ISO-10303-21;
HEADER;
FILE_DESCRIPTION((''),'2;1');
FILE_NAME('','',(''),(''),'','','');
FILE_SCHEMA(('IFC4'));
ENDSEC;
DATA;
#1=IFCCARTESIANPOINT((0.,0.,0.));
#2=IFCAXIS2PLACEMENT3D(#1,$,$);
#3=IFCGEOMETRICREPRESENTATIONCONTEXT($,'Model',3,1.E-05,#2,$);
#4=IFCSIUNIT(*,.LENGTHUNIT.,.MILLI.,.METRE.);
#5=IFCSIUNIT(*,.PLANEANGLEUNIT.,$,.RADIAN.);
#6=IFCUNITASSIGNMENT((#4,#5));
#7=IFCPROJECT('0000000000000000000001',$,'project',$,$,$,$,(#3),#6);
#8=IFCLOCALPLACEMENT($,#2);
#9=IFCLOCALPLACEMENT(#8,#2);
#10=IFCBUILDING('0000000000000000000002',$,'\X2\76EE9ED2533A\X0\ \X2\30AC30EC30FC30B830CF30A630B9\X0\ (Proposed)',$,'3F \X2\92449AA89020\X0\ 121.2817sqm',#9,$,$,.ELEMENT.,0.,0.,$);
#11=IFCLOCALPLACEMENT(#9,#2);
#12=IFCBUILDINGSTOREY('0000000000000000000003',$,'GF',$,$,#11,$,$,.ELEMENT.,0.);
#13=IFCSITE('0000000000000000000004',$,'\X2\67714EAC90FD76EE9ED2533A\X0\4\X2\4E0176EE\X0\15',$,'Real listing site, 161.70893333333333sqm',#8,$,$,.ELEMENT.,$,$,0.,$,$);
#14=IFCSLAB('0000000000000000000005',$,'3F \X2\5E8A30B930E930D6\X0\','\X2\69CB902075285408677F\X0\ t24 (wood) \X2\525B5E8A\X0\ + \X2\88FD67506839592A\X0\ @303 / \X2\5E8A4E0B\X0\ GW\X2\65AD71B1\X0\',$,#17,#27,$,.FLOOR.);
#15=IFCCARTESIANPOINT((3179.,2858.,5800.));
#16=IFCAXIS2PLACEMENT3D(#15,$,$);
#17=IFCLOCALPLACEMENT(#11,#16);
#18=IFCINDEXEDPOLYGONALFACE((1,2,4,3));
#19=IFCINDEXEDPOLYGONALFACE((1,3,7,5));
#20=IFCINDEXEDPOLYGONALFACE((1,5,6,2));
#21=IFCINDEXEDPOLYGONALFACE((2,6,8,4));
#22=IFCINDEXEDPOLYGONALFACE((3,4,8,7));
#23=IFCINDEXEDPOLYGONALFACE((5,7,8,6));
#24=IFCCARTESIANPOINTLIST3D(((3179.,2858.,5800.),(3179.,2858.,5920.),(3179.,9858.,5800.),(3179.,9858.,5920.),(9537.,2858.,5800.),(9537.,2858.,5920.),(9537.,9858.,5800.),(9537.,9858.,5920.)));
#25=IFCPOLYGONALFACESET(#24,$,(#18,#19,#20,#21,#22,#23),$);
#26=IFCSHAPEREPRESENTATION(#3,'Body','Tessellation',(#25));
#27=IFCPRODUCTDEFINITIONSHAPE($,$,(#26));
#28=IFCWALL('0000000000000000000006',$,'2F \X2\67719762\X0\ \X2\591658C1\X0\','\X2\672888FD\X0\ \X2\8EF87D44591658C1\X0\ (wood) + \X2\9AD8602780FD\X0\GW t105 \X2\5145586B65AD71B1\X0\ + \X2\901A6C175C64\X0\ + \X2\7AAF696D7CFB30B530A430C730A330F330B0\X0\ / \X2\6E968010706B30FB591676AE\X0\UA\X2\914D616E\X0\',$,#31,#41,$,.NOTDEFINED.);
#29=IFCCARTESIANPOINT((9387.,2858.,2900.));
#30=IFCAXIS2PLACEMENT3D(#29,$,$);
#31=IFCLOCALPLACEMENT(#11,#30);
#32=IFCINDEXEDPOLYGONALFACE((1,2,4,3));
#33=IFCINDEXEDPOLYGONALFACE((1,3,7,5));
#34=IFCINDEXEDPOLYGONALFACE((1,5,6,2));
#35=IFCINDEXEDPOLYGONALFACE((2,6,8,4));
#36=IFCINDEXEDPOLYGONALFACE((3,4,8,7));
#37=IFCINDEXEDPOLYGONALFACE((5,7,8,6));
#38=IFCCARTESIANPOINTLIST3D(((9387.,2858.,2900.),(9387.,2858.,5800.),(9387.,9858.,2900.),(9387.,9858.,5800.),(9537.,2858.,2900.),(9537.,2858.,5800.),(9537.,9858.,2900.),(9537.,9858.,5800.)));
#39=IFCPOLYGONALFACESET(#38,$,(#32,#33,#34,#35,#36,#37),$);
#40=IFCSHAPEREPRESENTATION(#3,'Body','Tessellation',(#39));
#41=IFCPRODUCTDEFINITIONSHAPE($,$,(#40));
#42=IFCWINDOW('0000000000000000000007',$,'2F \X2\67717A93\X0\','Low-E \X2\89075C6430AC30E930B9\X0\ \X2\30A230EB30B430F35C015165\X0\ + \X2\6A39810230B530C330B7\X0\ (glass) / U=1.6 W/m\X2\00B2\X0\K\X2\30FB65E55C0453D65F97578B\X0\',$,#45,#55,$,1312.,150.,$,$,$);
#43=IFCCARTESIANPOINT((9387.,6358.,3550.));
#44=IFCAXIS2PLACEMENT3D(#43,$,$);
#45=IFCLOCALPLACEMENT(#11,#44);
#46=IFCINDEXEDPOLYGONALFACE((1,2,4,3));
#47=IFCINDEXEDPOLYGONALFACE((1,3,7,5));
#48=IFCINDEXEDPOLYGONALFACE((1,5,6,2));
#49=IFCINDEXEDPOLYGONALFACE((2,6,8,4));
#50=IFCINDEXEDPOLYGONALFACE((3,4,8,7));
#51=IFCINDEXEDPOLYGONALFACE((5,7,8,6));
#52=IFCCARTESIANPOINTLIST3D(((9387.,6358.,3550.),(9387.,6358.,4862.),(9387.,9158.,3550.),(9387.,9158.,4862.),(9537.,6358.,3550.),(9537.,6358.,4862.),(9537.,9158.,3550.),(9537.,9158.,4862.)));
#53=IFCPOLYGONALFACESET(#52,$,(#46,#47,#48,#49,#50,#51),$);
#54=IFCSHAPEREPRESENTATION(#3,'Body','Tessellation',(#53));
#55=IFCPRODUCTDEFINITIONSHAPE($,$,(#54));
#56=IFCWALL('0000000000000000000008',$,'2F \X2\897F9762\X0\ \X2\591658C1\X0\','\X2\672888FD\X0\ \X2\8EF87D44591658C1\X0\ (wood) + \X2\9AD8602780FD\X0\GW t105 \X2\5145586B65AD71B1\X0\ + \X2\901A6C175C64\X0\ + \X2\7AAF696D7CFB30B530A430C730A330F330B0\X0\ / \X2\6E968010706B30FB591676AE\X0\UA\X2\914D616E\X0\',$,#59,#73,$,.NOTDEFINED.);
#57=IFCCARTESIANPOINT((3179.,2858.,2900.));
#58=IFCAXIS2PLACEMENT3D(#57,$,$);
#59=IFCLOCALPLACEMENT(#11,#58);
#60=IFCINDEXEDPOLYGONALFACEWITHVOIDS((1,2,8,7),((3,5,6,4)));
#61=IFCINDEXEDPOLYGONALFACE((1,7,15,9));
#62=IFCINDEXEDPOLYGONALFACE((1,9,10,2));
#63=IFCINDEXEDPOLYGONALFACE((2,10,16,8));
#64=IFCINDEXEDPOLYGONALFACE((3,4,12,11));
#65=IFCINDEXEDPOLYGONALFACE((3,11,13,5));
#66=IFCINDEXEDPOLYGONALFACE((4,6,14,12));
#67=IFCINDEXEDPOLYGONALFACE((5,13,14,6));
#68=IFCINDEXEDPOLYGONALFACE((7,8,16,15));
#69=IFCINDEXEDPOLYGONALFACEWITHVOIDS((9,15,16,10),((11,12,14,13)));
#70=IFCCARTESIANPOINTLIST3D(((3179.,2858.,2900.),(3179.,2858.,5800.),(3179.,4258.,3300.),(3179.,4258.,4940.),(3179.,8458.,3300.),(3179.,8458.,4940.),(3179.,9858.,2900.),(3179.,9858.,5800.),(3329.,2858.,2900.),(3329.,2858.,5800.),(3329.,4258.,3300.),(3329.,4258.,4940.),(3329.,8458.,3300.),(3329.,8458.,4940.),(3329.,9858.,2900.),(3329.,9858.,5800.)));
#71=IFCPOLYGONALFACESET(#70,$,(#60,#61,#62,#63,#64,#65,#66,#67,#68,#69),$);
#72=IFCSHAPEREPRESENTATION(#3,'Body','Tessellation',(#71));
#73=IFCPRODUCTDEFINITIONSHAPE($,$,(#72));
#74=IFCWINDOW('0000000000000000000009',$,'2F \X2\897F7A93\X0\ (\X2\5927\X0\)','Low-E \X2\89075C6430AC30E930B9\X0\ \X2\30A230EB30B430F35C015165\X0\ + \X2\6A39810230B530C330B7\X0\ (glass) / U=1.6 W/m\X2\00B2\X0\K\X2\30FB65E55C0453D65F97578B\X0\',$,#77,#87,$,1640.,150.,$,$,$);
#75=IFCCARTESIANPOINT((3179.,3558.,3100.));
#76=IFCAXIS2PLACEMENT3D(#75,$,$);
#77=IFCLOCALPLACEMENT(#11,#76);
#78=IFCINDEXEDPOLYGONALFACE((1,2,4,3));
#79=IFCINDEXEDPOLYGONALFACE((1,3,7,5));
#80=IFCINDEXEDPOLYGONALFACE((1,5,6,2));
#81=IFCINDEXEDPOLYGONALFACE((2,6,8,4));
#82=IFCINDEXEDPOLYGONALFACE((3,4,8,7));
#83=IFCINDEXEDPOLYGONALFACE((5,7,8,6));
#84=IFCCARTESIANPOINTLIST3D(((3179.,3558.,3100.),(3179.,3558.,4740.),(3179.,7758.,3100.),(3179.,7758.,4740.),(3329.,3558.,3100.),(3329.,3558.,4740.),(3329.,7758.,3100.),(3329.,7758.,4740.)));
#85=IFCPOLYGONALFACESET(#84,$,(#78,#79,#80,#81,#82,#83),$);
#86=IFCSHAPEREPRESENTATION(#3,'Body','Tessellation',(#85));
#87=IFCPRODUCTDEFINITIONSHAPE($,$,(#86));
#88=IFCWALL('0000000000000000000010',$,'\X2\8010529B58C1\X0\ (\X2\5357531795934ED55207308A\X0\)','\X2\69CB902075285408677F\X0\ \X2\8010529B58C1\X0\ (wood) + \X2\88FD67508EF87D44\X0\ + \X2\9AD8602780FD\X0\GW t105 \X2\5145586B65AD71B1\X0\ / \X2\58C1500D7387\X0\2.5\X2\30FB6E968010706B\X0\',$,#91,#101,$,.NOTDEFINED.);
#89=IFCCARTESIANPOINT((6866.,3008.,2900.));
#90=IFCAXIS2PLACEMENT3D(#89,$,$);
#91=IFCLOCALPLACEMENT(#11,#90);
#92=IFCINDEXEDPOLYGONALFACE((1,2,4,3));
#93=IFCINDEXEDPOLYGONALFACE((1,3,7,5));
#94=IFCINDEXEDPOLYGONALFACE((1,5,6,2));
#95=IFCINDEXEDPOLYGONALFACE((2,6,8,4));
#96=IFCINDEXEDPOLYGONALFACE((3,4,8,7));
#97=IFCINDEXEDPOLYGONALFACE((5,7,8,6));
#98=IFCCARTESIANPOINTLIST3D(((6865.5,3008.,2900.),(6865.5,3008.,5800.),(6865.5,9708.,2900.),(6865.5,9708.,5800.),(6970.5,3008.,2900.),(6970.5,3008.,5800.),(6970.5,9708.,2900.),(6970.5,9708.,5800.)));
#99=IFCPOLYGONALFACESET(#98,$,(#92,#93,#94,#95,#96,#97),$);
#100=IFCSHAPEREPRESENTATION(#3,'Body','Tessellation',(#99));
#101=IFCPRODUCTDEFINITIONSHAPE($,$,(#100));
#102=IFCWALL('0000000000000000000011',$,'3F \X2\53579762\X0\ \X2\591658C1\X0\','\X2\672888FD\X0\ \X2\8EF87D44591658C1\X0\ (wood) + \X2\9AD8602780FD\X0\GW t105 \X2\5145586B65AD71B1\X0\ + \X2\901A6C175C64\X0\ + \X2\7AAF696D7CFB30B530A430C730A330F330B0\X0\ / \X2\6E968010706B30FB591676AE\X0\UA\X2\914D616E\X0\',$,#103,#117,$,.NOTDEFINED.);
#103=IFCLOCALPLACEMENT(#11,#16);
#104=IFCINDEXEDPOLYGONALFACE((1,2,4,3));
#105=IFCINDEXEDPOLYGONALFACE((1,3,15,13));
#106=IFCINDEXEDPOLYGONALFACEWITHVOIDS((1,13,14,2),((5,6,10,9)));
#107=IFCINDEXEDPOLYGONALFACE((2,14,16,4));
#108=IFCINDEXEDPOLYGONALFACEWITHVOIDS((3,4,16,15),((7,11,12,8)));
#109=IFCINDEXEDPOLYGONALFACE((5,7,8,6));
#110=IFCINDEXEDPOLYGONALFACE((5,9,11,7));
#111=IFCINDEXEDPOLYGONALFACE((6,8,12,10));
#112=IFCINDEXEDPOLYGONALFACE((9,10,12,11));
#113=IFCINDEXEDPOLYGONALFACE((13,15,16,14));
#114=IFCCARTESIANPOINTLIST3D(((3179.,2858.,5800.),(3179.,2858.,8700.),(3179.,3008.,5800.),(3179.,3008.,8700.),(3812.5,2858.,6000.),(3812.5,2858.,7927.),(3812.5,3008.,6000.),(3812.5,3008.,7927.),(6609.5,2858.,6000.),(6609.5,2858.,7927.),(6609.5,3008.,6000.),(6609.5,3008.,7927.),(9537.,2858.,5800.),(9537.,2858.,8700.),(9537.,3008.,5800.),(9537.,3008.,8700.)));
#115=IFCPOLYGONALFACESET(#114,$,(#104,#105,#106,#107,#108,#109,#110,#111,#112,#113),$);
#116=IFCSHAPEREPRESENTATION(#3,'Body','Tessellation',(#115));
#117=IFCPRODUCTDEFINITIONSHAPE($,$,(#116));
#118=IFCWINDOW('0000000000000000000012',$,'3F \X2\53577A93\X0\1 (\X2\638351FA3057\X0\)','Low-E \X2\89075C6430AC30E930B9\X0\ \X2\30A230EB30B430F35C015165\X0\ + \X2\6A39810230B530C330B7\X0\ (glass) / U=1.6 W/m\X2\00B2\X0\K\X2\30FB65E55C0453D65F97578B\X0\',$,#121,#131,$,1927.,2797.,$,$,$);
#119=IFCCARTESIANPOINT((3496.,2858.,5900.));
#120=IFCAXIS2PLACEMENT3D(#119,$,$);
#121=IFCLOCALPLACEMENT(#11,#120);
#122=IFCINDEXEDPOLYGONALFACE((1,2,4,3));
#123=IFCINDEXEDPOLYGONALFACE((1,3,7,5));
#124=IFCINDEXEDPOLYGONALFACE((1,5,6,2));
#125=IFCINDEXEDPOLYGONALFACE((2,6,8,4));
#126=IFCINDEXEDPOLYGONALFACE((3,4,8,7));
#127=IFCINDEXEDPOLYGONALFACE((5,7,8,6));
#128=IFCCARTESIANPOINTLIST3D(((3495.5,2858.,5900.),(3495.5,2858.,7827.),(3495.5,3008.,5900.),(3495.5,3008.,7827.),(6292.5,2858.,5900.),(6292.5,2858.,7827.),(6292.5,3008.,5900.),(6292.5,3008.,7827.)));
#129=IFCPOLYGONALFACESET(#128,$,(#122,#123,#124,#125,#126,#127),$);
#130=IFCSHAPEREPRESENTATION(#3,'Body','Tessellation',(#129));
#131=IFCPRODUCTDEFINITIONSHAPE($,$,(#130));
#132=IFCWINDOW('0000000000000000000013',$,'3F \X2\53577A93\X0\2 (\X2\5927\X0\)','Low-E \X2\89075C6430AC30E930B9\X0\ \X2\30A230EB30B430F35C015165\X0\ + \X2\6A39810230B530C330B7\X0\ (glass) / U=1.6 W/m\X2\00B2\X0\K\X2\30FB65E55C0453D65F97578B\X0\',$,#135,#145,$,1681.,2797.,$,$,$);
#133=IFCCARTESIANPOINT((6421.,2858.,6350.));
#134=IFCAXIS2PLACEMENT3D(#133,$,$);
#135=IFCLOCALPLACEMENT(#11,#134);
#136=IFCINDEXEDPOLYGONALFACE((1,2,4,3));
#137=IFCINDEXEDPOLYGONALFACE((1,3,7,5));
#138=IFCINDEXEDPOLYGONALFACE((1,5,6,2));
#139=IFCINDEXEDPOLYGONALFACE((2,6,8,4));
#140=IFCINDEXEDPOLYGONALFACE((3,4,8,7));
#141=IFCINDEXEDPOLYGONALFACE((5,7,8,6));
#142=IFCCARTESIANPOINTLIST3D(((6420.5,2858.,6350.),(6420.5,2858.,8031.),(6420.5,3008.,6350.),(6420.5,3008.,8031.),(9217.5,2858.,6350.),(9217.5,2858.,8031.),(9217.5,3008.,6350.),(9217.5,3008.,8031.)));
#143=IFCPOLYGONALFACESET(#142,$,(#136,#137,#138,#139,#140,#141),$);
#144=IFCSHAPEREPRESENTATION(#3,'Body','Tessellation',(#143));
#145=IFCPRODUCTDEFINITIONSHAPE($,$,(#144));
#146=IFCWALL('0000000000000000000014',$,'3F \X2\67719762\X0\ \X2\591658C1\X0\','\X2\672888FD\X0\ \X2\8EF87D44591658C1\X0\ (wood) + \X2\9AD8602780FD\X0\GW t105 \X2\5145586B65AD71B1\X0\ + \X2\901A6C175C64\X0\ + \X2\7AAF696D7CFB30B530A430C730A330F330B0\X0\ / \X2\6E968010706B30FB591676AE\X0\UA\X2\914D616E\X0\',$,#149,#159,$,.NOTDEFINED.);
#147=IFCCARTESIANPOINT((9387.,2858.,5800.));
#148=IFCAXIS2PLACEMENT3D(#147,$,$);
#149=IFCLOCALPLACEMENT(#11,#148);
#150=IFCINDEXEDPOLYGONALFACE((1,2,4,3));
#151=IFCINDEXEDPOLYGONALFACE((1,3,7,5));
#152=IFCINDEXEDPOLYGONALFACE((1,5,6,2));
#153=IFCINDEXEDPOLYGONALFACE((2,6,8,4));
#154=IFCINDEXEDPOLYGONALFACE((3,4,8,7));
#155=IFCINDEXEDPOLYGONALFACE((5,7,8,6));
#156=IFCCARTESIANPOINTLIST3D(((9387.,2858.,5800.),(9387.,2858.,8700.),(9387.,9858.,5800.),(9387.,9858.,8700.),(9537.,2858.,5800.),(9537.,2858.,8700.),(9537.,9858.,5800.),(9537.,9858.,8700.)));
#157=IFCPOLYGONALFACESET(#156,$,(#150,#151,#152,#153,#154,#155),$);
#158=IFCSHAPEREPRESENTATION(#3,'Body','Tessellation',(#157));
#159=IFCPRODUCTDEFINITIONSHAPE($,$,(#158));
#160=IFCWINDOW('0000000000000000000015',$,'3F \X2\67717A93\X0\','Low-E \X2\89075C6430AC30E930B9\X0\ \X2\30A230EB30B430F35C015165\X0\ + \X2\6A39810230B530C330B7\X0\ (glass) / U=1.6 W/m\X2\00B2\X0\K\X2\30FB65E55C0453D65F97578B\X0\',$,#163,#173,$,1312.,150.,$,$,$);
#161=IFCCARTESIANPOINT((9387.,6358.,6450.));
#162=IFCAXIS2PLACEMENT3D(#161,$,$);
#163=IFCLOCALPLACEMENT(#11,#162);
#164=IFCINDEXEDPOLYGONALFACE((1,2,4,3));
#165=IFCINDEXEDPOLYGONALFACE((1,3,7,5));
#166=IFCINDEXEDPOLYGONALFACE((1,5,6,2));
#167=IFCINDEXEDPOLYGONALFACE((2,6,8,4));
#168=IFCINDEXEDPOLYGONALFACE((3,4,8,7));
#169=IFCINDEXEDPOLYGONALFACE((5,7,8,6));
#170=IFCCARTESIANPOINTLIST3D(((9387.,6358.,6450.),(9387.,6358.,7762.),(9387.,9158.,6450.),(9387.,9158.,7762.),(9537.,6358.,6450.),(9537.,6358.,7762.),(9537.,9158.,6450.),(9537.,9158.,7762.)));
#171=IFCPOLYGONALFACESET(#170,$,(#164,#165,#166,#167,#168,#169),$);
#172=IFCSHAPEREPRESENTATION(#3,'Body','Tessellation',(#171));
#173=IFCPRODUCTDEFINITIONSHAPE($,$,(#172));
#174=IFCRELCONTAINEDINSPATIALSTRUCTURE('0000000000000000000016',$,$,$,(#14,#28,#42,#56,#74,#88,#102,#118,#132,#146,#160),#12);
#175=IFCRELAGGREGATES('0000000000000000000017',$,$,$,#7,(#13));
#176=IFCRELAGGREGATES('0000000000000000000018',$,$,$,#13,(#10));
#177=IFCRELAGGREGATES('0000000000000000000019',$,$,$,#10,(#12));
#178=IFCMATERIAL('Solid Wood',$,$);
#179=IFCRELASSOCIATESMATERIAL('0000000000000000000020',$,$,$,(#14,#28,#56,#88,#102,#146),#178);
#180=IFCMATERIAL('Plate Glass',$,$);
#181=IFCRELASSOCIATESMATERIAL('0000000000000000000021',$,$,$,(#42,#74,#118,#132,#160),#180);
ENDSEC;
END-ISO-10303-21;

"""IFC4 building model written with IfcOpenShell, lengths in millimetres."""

from ifc_helpers import new_model, si_unit, frame, frame_2d, origin, place, context, project, spatial, rectangle, extrude, material, element, fill, save


model = new_model("IFC4")

# Units and contexts
model_context = context("Model", 3, precision=1e-05, world=origin())
ifc_project = project(units=[si_unit("LENGTHUNIT", "METRE", prefix="MILLI"), si_unit("PLANEANGLEUNIT", "RADIAN")], contexts=[model_context])

# Site, building, storey
site_placement = place(None, origin())
site = spatial("IfcSite", under=ifc_project, at=site_placement, Name="東京都目黒区4丁目15", ObjectType="Real listing site, 161.70893333333333sqm", CompositionType="ELEMENT", RefElevation=0.0)
building_placement = place(site_placement, origin())
building = spatial("IfcBuilding", under=site, at=building_placement, Name="目黒区 ガレージハウス (Proposed)", ObjectType="3F 鉄骨造 121.2817sqm", CompositionType="ELEMENT", ElevationOfRefHeight=0.0, ElevationOfTerrain=0.0)
storey_placement = place(building_placement, origin())
storey = spatial("IfcBuildingStorey", under=building, at=storey_placement, Name="GF", CompositionType="ELEMENT", Elevation=0.0)

# Slab
ifc_material_1 = material(Name="Solid Wood")
slab_placement = place(storey_placement, frame((3179.0, 2858.0, 5800.0)))
element("IfcSlab", 1, at=slab_placement, inside=storey, material=ifc_material_1, Name="3F 床スラブ", Description="構造用合板 t24 (wood) 剛床 + 製材根太 @303 / 床下 GW断熱", PredefinedType="FLOOR", context=model_context, shape_type="SweptSolid", body=[
    extrude(rectangle(XDim=6358.0, YDim=7000.0, at=frame_2d((3179.0, 3500.0))), frame((3179.0, 2858.0, 5800.0)), (0.0, 0.0, 1.0), 120.0),
])

# Walls, openings, windows
wall_1_placement = place(storey_placement, frame((9387.0, 2858.0, 2900.0)))
wall_1 = element("IfcWall", 2, at=wall_1_placement, inside=storey, material=ifc_material_1, Name="2F 東面 外壁", Description="木製 軸組外壁 (wood) + 高性能GW t105 充填断熱 + 通気層 + 窯業系サイディング / 準耐火・外皮UA配慮", PredefinedType="NOTDEFINED", context=model_context, shape_type="SweptSolid", body=[
    extrude(rectangle(XDim=150.0, YDim=7000.0, at=frame_2d((75.0, 3500.0))), frame((9387.0, 2858.0, 2900.0)), (0.0, 0.0, 1.0), 2900.0),
])
opening_1_placement = place(storey_placement, frame((9387.0, 6358.0, 3550.0)))
opening_1 = element("IfcOpeningElement", 3, at=opening_1_placement, cuts=wall_1, PredefinedType="NOTDEFINED", context=model_context, shape_type="SweptSolid", body=[
    extrude(rectangle(XDim=150.0, YDim=2800.0, at=frame_2d((75.0, 1400.0))), frame((9387.0, 6358.0, 3550.0)), (0.0, 0.0, 1.0), 1312.0),
])
ifc_material_2 = material(Name="Plate Glass")
window_1_placement = place(storey_placement, frame((9387.0, 6358.0, 3550.0)))
window_1 = element("IfcWindow", 4, at=window_1_placement, inside=storey, material=ifc_material_2, Name="2F 東窓", Description="Low-E 複層ガラス アルゴン封入 + 樹脂サッシ (glass) / U=1.6 W/m²K・日射取得型", OverallHeight=1312.0, OverallWidth=150.0, context=model_context, shape_type="SweptSolid", body=[
    extrude(rectangle(XDim=150.0, YDim=2800.0, at=frame_2d((75.0, 1400.0))), frame((9387.0, 6358.0, 3550.0)), (0.0, 0.0, 1.0), 1312.0),
])
fill(opening_1, window_1)
wall_2_placement = place(storey_placement, frame((3179.0, 2858.0, 2900.0)))
wall_2 = element("IfcWall", 5, at=wall_2_placement, inside=storey, material=ifc_material_1, Name="2F 西面 外壁", Description="木製 軸組外壁 (wood) + 高性能GW t105 充填断熱 + 通気層 + 窯業系サイディング / 準耐火・外皮UA配慮", PredefinedType="NOTDEFINED", context=model_context, shape_type="SweptSolid", body=[
    extrude(rectangle(XDim=150.0, YDim=7000.0, at=frame_2d((75.0, 3500.0))), frame((3179.0, 2858.0, 2900.0)), (0.0, 0.0, 1.0), 2900.0),
])
opening_2_placement = place(storey_placement, frame((3179.0, 3558.0, 3100.0)))
opening_2 = element("IfcOpeningElement", 6, at=opening_2_placement, cuts=wall_2, PredefinedType="NOTDEFINED", context=model_context, shape_type="SweptSolid", body=[
    extrude(rectangle(XDim=150.0, YDim=4200.0, at=frame_2d((75.0, 2100.0))), frame((3179.0, 3558.0, 3100.0)), (0.0, 0.0, 1.0), 1640.0),
])
window_2_placement = place(storey_placement, frame((3179.0, 3558.0, 3100.0)))
window_2 = element("IfcWindow", 7, at=window_2_placement, inside=storey, material=ifc_material_2, Name="2F 西窓 (大)", Description="Low-E 複層ガラス アルゴン封入 + 樹脂サッシ (glass) / U=1.6 W/m²K・日射取得型", OverallHeight=1640.0, OverallWidth=150.0, context=model_context, shape_type="SweptSolid", body=[
    extrude(rectangle(XDim=150.0, YDim=4200.0, at=frame_2d((75.0, 2100.0))), frame((3179.0, 3558.0, 3100.0)), (0.0, 0.0, 1.0), 1640.0),
])
fill(opening_2, window_2)

# Wall
wall_3_placement = place(storey_placement, frame((6866.0, 3008.0, 2900.0)))
element("IfcWall", 8, at=wall_3_placement, inside=storey, material=ifc_material_1, Name="耐力壁 (南北間仕切り)", Description="構造用合板 耐力壁 (wood) + 製材軸組 + 高性能GW t105 充填断熱 / 壁倍率2.5・準耐火", PredefinedType="NOTDEFINED", context=model_context, shape_type="SweptSolid", body=[
    extrude(rectangle(XDim=105.0, YDim=6700.0, at=frame_2d((52.0, 3350.0))), frame((6866.0, 3008.0, 2900.0)), (0.0, 0.0, 1.0), 2900.0),
])

# Wall, openings, windows
wall_4_placement = place(storey_placement, frame((3179.0, 2858.0, 5800.0)))
wall_4 = element("IfcWall", 9, at=wall_4_placement, inside=storey, material=ifc_material_1, Name="3F 南面 外壁", Description="木製 軸組外壁 (wood) + 高性能GW t105 充填断熱 + 通気層 + 窯業系サイディング / 準耐火・外皮UA配慮", PredefinedType="NOTDEFINED", context=model_context, shape_type="SweptSolid", body=[
    extrude(rectangle(XDim=6358.0, YDim=150.0, at=frame_2d((3179.0, 75.0))), frame((3179.0, 2858.0, 5800.0)), (0.0, 0.0, 1.0), 2900.0),
])
opening_3_placement = place(storey_placement, frame((3496.0, 2858.0, 5900.0)))
opening_3 = element("IfcOpeningElement", 10, at=opening_3_placement, cuts=wall_4, PredefinedType="NOTDEFINED", context=model_context, shape_type="SweptSolid", body=[
    extrude(rectangle(XDim=2797.0, YDim=150.0, at=frame_2d((1398.0, 75.0))), frame((3496.0, 2858.0, 5900.0)), (0.0, 0.0, 1.0), 1927.0),
])
opening_4_placement = place(storey_placement, frame((6421.0, 2858.0, 6350.0)))
opening_4 = element("IfcOpeningElement", 11, at=opening_4_placement, cuts=wall_4, PredefinedType="NOTDEFINED", context=model_context, shape_type="SweptSolid", body=[
    extrude(rectangle(XDim=2797.0, YDim=150.0, at=frame_2d((1398.0, 75.0))), frame((6421.0, 2858.0, 6350.0)), (0.0, 0.0, 1.0), 1681.0),
])
window_3_placement = place(storey_placement, frame((3496.0, 2858.0, 5900.0)))
window_3 = element("IfcWindow", 12, at=window_3_placement, inside=storey, material=ifc_material_2, Name="3F 南窓1 (掃出し)", Description="Low-E 複層ガラス アルゴン封入 + 樹脂サッシ (glass) / U=1.6 W/m²K・日射取得型", OverallHeight=1927.0, OverallWidth=2797.0, context=model_context, shape_type="SweptSolid", body=[
    extrude(rectangle(XDim=2797.0, YDim=150.0, at=frame_2d((1398.0, 75.0))), frame((3496.0, 2858.0, 5900.0)), (0.0, 0.0, 1.0), 1927.0),
])
fill(opening_3, window_3)
window_4_placement = place(storey_placement, frame((6421.0, 2858.0, 6350.0)))
window_4 = element("IfcWindow", 13, at=window_4_placement, inside=storey, material=ifc_material_2, Name="3F 南窓2 (大)", Description="Low-E 複層ガラス アルゴン封入 + 樹脂サッシ (glass) / U=1.6 W/m²K・日射取得型", OverallHeight=1681.0, OverallWidth=2797.0, context=model_context, shape_type="SweptSolid", body=[
    extrude(rectangle(XDim=2797.0, YDim=150.0, at=frame_2d((1398.0, 75.0))), frame((6421.0, 2858.0, 6350.0)), (0.0, 0.0, 1.0), 1681.0),
])
fill(opening_4, window_4)

# Wall, opening, window
wall_5_placement = place(storey_placement, frame((9387.0, 2858.0, 5800.0)))
wall_5 = element("IfcWall", 14, at=wall_5_placement, inside=storey, material=ifc_material_1, Name="3F 東面 外壁", Description="木製 軸組外壁 (wood) + 高性能GW t105 充填断熱 + 通気層 + 窯業系サイディング / 準耐火・外皮UA配慮", PredefinedType="NOTDEFINED", context=model_context, shape_type="SweptSolid", body=[
    extrude(rectangle(XDim=150.0, YDim=7000.0, at=frame_2d((75.0, 3500.0))), frame((9387.0, 2858.0, 5800.0)), (0.0, 0.0, 1.0), 2900.0),
])
opening_5_placement = place(storey_placement, frame((9387.0, 6358.0, 6450.0)))
opening_5 = element("IfcOpeningElement", 15, at=opening_5_placement, cuts=wall_5, PredefinedType="NOTDEFINED", context=model_context, shape_type="SweptSolid", body=[
    extrude(rectangle(XDim=150.0, YDim=2800.0, at=frame_2d((75.0, 1400.0))), frame((9387.0, 6358.0, 6450.0)), (0.0, 0.0, 1.0), 1312.0),
])
window_5_placement = place(storey_placement, frame((9387.0, 6358.0, 6450.0)))
window_5 = element("IfcWindow", 16, at=window_5_placement, inside=storey, material=ifc_material_2, Name="3F 東窓", Description="Low-E 複層ガラス アルゴン封入 + 樹脂サッシ (glass) / U=1.6 W/m²K・日射取得型", OverallHeight=1312.0, OverallWidth=150.0, context=model_context, shape_type="SweptSolid", body=[
    extrude(rectangle(XDim=150.0, YDim=2800.0, at=frame_2d((75.0, 1400.0))), frame((9387.0, 6358.0, 6450.0)), (0.0, 0.0, 1.0), 1312.0),
])
fill(opening_5, window_5)

save(model, "model.ifc")
